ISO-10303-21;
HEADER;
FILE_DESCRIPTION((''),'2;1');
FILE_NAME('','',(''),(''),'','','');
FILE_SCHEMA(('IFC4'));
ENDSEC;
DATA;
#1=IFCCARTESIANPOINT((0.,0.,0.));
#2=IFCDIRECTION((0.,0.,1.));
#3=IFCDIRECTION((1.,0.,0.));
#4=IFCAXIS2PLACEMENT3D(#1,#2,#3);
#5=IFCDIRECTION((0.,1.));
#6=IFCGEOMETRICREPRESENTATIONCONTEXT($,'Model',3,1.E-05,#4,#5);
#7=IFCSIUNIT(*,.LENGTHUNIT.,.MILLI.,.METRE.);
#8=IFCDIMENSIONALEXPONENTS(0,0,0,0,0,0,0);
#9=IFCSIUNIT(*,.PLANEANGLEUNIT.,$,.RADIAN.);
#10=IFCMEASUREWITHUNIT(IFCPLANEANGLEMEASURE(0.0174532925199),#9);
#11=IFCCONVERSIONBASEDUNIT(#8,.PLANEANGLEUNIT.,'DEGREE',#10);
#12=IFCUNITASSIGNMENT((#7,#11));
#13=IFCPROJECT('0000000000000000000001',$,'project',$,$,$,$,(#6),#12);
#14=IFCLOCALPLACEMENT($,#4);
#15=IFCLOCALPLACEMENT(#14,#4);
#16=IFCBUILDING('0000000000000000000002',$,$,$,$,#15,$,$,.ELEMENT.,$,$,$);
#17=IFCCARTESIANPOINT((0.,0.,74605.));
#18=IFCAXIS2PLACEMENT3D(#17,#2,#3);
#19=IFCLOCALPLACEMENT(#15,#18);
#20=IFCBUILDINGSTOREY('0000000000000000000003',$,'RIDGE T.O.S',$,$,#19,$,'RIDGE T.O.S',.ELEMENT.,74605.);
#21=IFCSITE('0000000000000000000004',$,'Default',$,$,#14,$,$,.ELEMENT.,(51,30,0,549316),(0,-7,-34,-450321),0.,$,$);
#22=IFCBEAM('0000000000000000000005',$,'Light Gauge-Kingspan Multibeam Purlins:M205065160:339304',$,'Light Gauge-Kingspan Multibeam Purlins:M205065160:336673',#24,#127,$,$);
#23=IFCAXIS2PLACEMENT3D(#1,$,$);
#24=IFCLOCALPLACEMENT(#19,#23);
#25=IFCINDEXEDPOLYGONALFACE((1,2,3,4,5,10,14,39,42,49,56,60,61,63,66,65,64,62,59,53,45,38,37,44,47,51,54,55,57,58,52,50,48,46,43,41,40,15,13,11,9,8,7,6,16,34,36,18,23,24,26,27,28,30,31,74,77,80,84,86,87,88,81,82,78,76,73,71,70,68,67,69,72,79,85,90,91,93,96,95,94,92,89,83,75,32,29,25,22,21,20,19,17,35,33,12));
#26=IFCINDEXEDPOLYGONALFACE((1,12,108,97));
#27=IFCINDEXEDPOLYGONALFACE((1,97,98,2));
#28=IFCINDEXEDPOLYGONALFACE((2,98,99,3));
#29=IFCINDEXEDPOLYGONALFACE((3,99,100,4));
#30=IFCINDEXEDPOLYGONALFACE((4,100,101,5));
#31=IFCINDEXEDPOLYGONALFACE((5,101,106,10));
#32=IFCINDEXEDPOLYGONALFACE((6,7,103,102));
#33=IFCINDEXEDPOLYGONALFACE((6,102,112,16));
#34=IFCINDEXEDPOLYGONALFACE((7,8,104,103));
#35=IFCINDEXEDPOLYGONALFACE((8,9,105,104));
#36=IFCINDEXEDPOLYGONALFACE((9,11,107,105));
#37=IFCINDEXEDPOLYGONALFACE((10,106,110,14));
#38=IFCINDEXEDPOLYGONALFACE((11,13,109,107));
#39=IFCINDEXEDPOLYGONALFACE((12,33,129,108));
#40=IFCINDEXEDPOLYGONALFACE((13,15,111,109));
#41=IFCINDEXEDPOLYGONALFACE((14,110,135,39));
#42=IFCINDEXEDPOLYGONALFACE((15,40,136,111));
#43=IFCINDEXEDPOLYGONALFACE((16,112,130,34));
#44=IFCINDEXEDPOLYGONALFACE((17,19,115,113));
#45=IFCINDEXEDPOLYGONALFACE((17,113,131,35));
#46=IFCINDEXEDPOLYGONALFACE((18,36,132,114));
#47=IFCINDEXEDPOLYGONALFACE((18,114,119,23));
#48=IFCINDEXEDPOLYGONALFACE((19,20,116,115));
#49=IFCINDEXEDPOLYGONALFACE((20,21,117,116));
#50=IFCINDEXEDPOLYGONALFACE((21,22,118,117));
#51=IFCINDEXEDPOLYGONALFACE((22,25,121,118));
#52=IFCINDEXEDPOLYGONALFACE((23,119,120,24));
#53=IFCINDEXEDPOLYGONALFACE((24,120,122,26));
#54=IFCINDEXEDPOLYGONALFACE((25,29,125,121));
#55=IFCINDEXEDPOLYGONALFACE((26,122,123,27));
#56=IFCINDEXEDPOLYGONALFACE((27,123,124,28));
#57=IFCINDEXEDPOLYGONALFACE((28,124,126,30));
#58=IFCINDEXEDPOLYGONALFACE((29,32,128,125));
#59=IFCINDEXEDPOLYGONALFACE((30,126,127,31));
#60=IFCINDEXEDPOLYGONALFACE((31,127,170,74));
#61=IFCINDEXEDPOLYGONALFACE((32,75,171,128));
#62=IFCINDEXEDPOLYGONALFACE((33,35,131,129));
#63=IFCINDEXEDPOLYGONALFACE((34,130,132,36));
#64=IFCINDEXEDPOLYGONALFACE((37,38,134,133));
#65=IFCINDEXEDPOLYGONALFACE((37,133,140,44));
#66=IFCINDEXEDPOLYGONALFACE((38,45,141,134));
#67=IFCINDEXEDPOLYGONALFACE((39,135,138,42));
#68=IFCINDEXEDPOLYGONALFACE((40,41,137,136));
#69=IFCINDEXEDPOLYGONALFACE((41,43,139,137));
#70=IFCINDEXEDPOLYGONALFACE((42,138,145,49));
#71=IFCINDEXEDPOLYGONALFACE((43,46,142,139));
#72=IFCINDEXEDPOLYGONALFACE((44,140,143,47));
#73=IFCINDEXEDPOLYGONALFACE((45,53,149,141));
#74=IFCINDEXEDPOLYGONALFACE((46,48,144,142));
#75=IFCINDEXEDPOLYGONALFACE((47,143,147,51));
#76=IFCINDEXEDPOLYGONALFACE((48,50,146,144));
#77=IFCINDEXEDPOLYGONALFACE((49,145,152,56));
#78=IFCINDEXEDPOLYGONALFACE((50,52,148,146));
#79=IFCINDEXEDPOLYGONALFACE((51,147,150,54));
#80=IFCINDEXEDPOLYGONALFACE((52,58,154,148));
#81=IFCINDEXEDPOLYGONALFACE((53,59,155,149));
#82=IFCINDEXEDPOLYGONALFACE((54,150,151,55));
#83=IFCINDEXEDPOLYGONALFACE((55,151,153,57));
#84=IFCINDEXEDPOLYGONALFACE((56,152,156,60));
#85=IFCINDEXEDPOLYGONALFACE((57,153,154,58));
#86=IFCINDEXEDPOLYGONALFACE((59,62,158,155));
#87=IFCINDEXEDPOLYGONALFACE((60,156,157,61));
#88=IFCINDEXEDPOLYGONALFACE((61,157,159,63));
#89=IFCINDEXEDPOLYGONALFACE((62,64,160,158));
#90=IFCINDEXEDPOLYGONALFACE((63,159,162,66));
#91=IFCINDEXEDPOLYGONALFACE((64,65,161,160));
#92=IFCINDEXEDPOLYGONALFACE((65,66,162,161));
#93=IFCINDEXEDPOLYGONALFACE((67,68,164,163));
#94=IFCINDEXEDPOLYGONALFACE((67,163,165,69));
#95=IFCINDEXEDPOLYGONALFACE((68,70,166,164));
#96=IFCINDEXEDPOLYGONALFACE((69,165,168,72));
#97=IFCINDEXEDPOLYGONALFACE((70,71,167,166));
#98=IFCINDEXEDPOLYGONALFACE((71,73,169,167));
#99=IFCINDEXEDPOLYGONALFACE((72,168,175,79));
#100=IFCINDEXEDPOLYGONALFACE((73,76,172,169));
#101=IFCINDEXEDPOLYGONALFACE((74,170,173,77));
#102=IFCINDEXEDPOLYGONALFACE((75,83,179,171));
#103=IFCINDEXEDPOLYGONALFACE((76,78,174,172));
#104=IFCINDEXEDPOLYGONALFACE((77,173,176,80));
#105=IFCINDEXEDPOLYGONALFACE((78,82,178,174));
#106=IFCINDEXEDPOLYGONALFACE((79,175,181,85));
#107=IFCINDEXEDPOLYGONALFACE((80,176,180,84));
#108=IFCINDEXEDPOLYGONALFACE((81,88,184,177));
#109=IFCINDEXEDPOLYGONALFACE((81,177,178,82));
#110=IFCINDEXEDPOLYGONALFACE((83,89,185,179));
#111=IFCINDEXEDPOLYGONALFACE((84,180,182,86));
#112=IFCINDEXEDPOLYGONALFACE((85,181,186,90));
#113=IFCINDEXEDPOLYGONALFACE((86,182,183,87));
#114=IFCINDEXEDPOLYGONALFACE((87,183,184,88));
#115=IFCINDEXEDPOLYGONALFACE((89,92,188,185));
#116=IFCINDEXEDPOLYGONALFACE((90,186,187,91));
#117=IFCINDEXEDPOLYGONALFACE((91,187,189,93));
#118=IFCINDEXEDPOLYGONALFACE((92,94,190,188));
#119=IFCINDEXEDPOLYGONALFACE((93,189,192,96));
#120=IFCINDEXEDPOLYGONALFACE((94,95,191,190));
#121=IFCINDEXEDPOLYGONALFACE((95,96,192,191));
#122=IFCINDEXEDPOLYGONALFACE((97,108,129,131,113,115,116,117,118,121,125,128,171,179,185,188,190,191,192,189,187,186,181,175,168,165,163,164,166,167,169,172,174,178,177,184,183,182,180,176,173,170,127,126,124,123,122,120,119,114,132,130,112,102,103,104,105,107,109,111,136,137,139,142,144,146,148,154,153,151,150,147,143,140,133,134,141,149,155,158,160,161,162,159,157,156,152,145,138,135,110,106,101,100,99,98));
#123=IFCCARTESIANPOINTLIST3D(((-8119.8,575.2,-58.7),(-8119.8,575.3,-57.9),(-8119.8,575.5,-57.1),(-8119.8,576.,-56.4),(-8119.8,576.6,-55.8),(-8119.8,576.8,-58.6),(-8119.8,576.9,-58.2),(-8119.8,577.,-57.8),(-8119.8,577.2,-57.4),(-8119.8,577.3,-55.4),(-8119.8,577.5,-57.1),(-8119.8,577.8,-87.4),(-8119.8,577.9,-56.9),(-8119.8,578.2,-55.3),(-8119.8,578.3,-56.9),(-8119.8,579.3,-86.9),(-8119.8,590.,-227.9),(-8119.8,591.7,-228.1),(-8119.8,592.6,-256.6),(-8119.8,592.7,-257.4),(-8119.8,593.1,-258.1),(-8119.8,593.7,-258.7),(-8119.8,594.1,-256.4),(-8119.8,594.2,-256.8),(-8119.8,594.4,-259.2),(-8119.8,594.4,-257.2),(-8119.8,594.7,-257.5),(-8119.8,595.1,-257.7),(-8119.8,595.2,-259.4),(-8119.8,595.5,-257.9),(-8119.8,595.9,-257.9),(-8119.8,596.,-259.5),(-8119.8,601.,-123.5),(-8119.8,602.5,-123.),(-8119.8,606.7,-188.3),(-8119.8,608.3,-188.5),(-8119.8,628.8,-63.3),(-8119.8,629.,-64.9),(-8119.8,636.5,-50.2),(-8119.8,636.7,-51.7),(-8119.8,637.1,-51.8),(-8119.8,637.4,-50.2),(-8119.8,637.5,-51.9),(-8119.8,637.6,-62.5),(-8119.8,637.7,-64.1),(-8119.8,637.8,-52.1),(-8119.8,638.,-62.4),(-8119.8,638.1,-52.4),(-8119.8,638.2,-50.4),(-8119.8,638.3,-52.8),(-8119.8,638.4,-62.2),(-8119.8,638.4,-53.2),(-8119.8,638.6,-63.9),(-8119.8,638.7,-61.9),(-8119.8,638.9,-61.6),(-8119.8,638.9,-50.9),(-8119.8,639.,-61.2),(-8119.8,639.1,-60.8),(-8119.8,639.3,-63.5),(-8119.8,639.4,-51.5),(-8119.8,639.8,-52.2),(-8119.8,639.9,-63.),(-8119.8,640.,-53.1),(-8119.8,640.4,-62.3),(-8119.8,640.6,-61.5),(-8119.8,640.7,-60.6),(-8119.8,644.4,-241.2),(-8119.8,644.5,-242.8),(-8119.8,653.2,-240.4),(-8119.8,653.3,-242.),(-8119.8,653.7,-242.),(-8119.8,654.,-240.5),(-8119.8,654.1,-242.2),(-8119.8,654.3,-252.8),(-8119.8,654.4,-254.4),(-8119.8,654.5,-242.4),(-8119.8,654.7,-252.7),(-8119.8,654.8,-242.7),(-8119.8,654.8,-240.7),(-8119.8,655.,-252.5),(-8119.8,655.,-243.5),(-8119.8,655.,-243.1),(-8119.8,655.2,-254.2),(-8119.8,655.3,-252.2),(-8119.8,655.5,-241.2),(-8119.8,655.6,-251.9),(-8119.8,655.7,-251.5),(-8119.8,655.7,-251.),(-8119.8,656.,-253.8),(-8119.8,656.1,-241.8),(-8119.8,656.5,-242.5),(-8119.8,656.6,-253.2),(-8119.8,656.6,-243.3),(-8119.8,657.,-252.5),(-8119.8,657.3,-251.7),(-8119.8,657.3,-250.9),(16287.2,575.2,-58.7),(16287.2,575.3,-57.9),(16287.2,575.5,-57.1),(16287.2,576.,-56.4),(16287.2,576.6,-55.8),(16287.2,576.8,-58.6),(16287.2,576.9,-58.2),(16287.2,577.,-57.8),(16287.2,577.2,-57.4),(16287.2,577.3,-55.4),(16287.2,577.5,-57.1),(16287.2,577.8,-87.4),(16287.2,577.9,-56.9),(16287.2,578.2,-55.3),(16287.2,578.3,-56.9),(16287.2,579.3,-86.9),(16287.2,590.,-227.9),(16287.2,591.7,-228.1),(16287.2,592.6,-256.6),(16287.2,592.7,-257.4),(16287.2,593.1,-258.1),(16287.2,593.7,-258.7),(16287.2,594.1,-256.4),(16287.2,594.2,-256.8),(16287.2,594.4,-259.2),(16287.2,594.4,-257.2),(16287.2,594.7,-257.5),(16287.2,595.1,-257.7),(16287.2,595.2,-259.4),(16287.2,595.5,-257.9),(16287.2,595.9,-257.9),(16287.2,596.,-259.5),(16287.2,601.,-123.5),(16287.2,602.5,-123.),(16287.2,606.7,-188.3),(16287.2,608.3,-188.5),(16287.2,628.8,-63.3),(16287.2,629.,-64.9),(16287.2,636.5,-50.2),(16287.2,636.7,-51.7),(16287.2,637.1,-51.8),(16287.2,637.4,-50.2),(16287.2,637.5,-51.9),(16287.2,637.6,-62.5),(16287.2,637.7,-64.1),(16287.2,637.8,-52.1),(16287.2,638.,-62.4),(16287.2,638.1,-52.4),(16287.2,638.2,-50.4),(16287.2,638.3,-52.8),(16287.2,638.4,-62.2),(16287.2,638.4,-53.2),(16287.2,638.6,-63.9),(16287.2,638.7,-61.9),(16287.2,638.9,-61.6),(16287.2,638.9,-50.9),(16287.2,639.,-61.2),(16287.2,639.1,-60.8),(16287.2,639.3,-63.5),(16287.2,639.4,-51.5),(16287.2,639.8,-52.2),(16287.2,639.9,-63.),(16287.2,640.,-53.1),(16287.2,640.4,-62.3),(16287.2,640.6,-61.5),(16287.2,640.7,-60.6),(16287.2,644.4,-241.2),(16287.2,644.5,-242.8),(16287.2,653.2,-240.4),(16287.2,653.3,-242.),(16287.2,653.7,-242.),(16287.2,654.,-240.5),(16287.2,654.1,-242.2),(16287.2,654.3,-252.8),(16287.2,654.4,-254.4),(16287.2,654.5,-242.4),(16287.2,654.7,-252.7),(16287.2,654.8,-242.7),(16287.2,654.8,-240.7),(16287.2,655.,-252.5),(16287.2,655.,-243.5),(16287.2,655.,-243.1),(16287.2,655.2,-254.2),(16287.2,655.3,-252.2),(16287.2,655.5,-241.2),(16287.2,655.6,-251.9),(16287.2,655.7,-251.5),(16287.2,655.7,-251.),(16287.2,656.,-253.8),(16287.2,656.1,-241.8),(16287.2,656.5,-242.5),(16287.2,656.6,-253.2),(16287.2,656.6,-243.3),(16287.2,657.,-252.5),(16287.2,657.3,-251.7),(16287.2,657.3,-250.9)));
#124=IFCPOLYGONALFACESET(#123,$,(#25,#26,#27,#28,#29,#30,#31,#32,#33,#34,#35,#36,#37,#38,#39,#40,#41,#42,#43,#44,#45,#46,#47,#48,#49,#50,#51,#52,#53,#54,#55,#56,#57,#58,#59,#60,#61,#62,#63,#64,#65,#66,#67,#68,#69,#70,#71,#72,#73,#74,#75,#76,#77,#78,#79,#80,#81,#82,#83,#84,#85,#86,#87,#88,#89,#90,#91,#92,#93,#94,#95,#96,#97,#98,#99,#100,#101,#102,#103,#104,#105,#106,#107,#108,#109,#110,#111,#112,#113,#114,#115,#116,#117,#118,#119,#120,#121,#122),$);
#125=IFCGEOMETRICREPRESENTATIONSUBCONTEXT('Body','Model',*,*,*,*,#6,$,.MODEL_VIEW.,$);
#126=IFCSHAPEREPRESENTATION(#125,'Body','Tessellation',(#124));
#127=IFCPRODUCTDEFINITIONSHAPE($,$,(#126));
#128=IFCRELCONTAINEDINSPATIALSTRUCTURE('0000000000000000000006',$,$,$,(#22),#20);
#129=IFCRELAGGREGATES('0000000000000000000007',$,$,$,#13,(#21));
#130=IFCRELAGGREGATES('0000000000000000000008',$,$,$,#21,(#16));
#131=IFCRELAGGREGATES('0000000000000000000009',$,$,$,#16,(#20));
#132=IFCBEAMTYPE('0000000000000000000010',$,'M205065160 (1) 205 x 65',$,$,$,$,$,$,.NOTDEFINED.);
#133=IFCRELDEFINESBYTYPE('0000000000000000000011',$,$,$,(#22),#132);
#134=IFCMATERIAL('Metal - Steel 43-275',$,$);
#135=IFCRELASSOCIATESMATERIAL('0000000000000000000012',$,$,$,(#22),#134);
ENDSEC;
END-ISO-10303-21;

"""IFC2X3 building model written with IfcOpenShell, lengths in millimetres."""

from ifc_helpers import new_model, entity, si_unit, converted_unit, point, direction, frame, frame_2d, origin_with_axes, place, context, subcontext, project, spatial, polyline, circle_curve, parameter, trimmed, segment, composite_curve, outline, extrude, material, type_object, element, save


model = new_model("IFC2X3")

# Units and contexts
model_context = context("Model", 3, precision=1e-05, world=origin_with_axes(), true_north=direction((0.0, 1.0)))
body_context = subcontext(model_context, "Body", "Model", "MODEL_VIEW")
ifc_project = project(units=[si_unit("LENGTHUNIT", "METRE", prefix="MILLI"), converted_unit("PLANEANGLEUNIT", "DEGREE", entity("IfcPlaneAngleMeasure", 0.0174532925199), si_unit("PLANEANGLEUNIT", "RADIAN"), dimensions=[0, 0, 0, 0, 0, 0, 0])], contexts=[model_context])

# Site, building, storey
site_placement = place(None, origin_with_axes())
site = spatial("IfcSite", under=ifc_project, at=site_placement, Name="Default", CompositionType="ELEMENT", RefLatitude=(51, 30, 0, 549316), RefLongitude=(0, -7, -34, -450321), RefElevation=0.0)
building_placement = place(site_placement, origin_with_axes())
building = spatial("IfcBuilding", under=site, at=building_placement, CompositionType="ELEMENT")
storey_placement = place(building_placement, frame((0.0, 0.0, 74605.0), z_axis=(0.0, 0.0, 1.0), x_axis=(1.0, 0.0, 0.0)))
storey = spatial("IfcBuildingStorey", under=building, at=storey_placement, Name="RIDGE T.O.S", LongName="RIDGE T.O.S", CompositionType="ELEMENT", Elevation=74605.0)

# Beam
ifc_material = material(Name="Metal - Steel 43-275")
beam_type_1 = type_object("IfcBeamType", Name="M205065160 (1) 205 x 65", PredefinedType="NOTDEFINED")
beam_1_placement = place(storey_placement, frame((16287.2, 620.5, -154.5), z_axis=(0.0, 0.0, 1.0), x_axis=(0.0, 1.0, 0.0)))
element("IfcBeam", 1, at=beam_1_placement, inside=storey, type_object=beam_type_1, material=ifc_material, Name="Light Gauge-Kingspan Multibeam Purlins:M205065160:339304", ObjectType="Light Gauge-Kingspan Multibeam Purlins:M205065160:336673", context=body_context, shape_type="SweptSolid", body=[
    extrude(outline(composite_curve([segment(polyline([(91.7, -28.3), (99.3, -28.3)]), True, "CONTINUOUS"), segment(trimmed(circle_curve(frame_2d((99.3, -25.1), x_axis=(0.0, -1.0)), 3.2), [point((99.3, -28.3)), parameter(0.0)], [point((102.5, -25.1)), parameter(90.0)], True, "CARTESIAN"), True, "CONTINUOUS"), segment(polyline([(102.5, -25.1), (102.5, 33.5)]), True, "CONTINUOUS"), segment(trimmed(circle_curve(frame_2d((99.3, 33.5), x_axis=(1.0, 0.0)), 3.2), [point((102.5, 33.5)), parameter(0.0)], [point((99.3, 36.7)), parameter(90.0)], True, "CARTESIAN"), True, "CONTINUOUS"), segment(polyline([(99.3, 36.7), (70.5, 36.7), (32.5, 16.7), (-32.5, 16.7), (-70.5, 36.7), (-99.3, 36.7)]), True, "CONTINUOUS"), segment(trimmed(circle_curve(frame_2d((-99.3, 33.5), x_axis=(0.0, 1.0)), 3.2), [point((-99.3, 36.7)), parameter(0.0)], [point((-102.5, 33.5)), parameter(90.0)], True, "CARTESIAN"), True, "CONTINUOUS"), segment(polyline([(-102.5, 33.5), (-102.5, -25.1)]), True, "CONTINUOUS"), segment(trimmed(circle_curve(frame_2d((-99.3, -25.1), x_axis=(-1.0, 0.0)), 3.2), [point((-102.5, -25.1)), parameter(0.0)], [point((-99.3, -28.3)), parameter(90.0)], True, "CARTESIAN"), True, "CONTINUOUS"), segment(polyline([(-99.3, -28.3), (-91.7, -28.3)]), True, "CONTINUOUS"), segment(trimmed(circle_curve(frame_2d((-91.7, -25.1), x_axis=(0.0, -1.0)), 3.2), [point((-91.7, -28.3)), parameter(0.0)], [point((-88.5, -25.1)), parameter(90.0)], True, "CARTESIAN"), True, "CONTINUOUS"), segment(polyline([(-88.5, -25.1), (-88.5, -16.3), (-90.1, -16.3), (-90.1, -25.1)]), True, "CONTINUOUS"), segment(trimmed(circle_curve(frame_2d((-91.7, -25.1), x_axis=(0.0, -1.0)), 1.6), [point((-90.1, -25.1)), parameter(90.0)], [point((-91.7, -26.7)), parameter(0.0)], False, "CARTESIAN"), True, "CONTINUOUS"), segment(polyline([(-91.7, -26.7), (-99.3, -26.7)]), True, "CONTINUOUS"), segment(trimmed(circle_curve(frame_2d((-99.3, -25.1), x_axis=(-1.0, 0.0)), 1.6), [point((-99.3, -26.7)), parameter(90.0)], [point((-100.9, -25.1)), parameter(0.0)], False, "CARTESIAN"), True, "CONTINUOUS"), segment(polyline([(-100.9, -25.1), (-100.9, 33.5)]), True, "CONTINUOUS"), segment(trimmed(circle_curve(frame_2d((-99.3, 33.5), x_axis=(0.0, 1.0)), 1.6), [point((-100.9, 33.5)), parameter(90.0)], [point((-99.3, 35.1)), parameter(0.0)], False, "CARTESIAN"), True, "CONTINUOUS"), segment(polyline([(-99.3, 35.1), (-70.9, 35.1), (-32.9, 15.1), (32.9, 15.1), (70.9, 35.1), (99.3, 35.1)]), True, "CONTINUOUS"), segment(trimmed(circle_curve(frame_2d((99.3, 33.5), x_axis=(1.0, 0.0)), 1.6), [point((99.3, 35.1)), parameter(90.0)], [point((100.9, 33.5)), parameter(0.0)], False, "CARTESIAN"), True, "CONTINUOUS"), segment(polyline([(100.9, 33.5), (100.9, -25.1)]), True, "CONTINUOUS"), segment(trimmed(circle_curve(frame_2d((99.3, -25.1), x_axis=(0.0, -1.0)), 1.6), [point((100.9, -25.1)), parameter(90.0)], [point((99.3, -26.7)), parameter(0.0)], False, "CARTESIAN"), True, "CONTINUOUS"), segment(polyline([(99.3, -26.7), (91.7, -26.7)]), True, "CONTINUOUS"), segment(trimmed(circle_curve(frame_2d((91.7, -25.1), x_axis=(-1.0, 0.0)), 1.6), [point((91.7, -26.7)), parameter(90.0)], [point((90.1, -25.1)), parameter(0.0)], False, "CARTESIAN"), True, "CONTINUOUS"), segment(polyline([(90.1, -25.1), (90.1, -16.3), (88.5, -16.3), (88.5, -25.1)]), True, "CONTINUOUS"), segment(trimmed(circle_curve(frame_2d((91.7, -25.1), x_axis=(-1.0, 0.0)), 3.2), [point((88.5, -25.1)), parameter(0.0)], [point((91.7, -28.3)), parameter(90.0)], True, "CARTESIAN"), True, "CONTINUOUS")], self_intersect=False)), frame((0.0, 24407.0, 0.0), z_axis=(0.0, -1.0, 0.0), x_axis=(-0.087156, 0.0, 0.996195)), (0.0, 0.0, 1.0), 24407.0),
])

save(model, "model.ifc")
